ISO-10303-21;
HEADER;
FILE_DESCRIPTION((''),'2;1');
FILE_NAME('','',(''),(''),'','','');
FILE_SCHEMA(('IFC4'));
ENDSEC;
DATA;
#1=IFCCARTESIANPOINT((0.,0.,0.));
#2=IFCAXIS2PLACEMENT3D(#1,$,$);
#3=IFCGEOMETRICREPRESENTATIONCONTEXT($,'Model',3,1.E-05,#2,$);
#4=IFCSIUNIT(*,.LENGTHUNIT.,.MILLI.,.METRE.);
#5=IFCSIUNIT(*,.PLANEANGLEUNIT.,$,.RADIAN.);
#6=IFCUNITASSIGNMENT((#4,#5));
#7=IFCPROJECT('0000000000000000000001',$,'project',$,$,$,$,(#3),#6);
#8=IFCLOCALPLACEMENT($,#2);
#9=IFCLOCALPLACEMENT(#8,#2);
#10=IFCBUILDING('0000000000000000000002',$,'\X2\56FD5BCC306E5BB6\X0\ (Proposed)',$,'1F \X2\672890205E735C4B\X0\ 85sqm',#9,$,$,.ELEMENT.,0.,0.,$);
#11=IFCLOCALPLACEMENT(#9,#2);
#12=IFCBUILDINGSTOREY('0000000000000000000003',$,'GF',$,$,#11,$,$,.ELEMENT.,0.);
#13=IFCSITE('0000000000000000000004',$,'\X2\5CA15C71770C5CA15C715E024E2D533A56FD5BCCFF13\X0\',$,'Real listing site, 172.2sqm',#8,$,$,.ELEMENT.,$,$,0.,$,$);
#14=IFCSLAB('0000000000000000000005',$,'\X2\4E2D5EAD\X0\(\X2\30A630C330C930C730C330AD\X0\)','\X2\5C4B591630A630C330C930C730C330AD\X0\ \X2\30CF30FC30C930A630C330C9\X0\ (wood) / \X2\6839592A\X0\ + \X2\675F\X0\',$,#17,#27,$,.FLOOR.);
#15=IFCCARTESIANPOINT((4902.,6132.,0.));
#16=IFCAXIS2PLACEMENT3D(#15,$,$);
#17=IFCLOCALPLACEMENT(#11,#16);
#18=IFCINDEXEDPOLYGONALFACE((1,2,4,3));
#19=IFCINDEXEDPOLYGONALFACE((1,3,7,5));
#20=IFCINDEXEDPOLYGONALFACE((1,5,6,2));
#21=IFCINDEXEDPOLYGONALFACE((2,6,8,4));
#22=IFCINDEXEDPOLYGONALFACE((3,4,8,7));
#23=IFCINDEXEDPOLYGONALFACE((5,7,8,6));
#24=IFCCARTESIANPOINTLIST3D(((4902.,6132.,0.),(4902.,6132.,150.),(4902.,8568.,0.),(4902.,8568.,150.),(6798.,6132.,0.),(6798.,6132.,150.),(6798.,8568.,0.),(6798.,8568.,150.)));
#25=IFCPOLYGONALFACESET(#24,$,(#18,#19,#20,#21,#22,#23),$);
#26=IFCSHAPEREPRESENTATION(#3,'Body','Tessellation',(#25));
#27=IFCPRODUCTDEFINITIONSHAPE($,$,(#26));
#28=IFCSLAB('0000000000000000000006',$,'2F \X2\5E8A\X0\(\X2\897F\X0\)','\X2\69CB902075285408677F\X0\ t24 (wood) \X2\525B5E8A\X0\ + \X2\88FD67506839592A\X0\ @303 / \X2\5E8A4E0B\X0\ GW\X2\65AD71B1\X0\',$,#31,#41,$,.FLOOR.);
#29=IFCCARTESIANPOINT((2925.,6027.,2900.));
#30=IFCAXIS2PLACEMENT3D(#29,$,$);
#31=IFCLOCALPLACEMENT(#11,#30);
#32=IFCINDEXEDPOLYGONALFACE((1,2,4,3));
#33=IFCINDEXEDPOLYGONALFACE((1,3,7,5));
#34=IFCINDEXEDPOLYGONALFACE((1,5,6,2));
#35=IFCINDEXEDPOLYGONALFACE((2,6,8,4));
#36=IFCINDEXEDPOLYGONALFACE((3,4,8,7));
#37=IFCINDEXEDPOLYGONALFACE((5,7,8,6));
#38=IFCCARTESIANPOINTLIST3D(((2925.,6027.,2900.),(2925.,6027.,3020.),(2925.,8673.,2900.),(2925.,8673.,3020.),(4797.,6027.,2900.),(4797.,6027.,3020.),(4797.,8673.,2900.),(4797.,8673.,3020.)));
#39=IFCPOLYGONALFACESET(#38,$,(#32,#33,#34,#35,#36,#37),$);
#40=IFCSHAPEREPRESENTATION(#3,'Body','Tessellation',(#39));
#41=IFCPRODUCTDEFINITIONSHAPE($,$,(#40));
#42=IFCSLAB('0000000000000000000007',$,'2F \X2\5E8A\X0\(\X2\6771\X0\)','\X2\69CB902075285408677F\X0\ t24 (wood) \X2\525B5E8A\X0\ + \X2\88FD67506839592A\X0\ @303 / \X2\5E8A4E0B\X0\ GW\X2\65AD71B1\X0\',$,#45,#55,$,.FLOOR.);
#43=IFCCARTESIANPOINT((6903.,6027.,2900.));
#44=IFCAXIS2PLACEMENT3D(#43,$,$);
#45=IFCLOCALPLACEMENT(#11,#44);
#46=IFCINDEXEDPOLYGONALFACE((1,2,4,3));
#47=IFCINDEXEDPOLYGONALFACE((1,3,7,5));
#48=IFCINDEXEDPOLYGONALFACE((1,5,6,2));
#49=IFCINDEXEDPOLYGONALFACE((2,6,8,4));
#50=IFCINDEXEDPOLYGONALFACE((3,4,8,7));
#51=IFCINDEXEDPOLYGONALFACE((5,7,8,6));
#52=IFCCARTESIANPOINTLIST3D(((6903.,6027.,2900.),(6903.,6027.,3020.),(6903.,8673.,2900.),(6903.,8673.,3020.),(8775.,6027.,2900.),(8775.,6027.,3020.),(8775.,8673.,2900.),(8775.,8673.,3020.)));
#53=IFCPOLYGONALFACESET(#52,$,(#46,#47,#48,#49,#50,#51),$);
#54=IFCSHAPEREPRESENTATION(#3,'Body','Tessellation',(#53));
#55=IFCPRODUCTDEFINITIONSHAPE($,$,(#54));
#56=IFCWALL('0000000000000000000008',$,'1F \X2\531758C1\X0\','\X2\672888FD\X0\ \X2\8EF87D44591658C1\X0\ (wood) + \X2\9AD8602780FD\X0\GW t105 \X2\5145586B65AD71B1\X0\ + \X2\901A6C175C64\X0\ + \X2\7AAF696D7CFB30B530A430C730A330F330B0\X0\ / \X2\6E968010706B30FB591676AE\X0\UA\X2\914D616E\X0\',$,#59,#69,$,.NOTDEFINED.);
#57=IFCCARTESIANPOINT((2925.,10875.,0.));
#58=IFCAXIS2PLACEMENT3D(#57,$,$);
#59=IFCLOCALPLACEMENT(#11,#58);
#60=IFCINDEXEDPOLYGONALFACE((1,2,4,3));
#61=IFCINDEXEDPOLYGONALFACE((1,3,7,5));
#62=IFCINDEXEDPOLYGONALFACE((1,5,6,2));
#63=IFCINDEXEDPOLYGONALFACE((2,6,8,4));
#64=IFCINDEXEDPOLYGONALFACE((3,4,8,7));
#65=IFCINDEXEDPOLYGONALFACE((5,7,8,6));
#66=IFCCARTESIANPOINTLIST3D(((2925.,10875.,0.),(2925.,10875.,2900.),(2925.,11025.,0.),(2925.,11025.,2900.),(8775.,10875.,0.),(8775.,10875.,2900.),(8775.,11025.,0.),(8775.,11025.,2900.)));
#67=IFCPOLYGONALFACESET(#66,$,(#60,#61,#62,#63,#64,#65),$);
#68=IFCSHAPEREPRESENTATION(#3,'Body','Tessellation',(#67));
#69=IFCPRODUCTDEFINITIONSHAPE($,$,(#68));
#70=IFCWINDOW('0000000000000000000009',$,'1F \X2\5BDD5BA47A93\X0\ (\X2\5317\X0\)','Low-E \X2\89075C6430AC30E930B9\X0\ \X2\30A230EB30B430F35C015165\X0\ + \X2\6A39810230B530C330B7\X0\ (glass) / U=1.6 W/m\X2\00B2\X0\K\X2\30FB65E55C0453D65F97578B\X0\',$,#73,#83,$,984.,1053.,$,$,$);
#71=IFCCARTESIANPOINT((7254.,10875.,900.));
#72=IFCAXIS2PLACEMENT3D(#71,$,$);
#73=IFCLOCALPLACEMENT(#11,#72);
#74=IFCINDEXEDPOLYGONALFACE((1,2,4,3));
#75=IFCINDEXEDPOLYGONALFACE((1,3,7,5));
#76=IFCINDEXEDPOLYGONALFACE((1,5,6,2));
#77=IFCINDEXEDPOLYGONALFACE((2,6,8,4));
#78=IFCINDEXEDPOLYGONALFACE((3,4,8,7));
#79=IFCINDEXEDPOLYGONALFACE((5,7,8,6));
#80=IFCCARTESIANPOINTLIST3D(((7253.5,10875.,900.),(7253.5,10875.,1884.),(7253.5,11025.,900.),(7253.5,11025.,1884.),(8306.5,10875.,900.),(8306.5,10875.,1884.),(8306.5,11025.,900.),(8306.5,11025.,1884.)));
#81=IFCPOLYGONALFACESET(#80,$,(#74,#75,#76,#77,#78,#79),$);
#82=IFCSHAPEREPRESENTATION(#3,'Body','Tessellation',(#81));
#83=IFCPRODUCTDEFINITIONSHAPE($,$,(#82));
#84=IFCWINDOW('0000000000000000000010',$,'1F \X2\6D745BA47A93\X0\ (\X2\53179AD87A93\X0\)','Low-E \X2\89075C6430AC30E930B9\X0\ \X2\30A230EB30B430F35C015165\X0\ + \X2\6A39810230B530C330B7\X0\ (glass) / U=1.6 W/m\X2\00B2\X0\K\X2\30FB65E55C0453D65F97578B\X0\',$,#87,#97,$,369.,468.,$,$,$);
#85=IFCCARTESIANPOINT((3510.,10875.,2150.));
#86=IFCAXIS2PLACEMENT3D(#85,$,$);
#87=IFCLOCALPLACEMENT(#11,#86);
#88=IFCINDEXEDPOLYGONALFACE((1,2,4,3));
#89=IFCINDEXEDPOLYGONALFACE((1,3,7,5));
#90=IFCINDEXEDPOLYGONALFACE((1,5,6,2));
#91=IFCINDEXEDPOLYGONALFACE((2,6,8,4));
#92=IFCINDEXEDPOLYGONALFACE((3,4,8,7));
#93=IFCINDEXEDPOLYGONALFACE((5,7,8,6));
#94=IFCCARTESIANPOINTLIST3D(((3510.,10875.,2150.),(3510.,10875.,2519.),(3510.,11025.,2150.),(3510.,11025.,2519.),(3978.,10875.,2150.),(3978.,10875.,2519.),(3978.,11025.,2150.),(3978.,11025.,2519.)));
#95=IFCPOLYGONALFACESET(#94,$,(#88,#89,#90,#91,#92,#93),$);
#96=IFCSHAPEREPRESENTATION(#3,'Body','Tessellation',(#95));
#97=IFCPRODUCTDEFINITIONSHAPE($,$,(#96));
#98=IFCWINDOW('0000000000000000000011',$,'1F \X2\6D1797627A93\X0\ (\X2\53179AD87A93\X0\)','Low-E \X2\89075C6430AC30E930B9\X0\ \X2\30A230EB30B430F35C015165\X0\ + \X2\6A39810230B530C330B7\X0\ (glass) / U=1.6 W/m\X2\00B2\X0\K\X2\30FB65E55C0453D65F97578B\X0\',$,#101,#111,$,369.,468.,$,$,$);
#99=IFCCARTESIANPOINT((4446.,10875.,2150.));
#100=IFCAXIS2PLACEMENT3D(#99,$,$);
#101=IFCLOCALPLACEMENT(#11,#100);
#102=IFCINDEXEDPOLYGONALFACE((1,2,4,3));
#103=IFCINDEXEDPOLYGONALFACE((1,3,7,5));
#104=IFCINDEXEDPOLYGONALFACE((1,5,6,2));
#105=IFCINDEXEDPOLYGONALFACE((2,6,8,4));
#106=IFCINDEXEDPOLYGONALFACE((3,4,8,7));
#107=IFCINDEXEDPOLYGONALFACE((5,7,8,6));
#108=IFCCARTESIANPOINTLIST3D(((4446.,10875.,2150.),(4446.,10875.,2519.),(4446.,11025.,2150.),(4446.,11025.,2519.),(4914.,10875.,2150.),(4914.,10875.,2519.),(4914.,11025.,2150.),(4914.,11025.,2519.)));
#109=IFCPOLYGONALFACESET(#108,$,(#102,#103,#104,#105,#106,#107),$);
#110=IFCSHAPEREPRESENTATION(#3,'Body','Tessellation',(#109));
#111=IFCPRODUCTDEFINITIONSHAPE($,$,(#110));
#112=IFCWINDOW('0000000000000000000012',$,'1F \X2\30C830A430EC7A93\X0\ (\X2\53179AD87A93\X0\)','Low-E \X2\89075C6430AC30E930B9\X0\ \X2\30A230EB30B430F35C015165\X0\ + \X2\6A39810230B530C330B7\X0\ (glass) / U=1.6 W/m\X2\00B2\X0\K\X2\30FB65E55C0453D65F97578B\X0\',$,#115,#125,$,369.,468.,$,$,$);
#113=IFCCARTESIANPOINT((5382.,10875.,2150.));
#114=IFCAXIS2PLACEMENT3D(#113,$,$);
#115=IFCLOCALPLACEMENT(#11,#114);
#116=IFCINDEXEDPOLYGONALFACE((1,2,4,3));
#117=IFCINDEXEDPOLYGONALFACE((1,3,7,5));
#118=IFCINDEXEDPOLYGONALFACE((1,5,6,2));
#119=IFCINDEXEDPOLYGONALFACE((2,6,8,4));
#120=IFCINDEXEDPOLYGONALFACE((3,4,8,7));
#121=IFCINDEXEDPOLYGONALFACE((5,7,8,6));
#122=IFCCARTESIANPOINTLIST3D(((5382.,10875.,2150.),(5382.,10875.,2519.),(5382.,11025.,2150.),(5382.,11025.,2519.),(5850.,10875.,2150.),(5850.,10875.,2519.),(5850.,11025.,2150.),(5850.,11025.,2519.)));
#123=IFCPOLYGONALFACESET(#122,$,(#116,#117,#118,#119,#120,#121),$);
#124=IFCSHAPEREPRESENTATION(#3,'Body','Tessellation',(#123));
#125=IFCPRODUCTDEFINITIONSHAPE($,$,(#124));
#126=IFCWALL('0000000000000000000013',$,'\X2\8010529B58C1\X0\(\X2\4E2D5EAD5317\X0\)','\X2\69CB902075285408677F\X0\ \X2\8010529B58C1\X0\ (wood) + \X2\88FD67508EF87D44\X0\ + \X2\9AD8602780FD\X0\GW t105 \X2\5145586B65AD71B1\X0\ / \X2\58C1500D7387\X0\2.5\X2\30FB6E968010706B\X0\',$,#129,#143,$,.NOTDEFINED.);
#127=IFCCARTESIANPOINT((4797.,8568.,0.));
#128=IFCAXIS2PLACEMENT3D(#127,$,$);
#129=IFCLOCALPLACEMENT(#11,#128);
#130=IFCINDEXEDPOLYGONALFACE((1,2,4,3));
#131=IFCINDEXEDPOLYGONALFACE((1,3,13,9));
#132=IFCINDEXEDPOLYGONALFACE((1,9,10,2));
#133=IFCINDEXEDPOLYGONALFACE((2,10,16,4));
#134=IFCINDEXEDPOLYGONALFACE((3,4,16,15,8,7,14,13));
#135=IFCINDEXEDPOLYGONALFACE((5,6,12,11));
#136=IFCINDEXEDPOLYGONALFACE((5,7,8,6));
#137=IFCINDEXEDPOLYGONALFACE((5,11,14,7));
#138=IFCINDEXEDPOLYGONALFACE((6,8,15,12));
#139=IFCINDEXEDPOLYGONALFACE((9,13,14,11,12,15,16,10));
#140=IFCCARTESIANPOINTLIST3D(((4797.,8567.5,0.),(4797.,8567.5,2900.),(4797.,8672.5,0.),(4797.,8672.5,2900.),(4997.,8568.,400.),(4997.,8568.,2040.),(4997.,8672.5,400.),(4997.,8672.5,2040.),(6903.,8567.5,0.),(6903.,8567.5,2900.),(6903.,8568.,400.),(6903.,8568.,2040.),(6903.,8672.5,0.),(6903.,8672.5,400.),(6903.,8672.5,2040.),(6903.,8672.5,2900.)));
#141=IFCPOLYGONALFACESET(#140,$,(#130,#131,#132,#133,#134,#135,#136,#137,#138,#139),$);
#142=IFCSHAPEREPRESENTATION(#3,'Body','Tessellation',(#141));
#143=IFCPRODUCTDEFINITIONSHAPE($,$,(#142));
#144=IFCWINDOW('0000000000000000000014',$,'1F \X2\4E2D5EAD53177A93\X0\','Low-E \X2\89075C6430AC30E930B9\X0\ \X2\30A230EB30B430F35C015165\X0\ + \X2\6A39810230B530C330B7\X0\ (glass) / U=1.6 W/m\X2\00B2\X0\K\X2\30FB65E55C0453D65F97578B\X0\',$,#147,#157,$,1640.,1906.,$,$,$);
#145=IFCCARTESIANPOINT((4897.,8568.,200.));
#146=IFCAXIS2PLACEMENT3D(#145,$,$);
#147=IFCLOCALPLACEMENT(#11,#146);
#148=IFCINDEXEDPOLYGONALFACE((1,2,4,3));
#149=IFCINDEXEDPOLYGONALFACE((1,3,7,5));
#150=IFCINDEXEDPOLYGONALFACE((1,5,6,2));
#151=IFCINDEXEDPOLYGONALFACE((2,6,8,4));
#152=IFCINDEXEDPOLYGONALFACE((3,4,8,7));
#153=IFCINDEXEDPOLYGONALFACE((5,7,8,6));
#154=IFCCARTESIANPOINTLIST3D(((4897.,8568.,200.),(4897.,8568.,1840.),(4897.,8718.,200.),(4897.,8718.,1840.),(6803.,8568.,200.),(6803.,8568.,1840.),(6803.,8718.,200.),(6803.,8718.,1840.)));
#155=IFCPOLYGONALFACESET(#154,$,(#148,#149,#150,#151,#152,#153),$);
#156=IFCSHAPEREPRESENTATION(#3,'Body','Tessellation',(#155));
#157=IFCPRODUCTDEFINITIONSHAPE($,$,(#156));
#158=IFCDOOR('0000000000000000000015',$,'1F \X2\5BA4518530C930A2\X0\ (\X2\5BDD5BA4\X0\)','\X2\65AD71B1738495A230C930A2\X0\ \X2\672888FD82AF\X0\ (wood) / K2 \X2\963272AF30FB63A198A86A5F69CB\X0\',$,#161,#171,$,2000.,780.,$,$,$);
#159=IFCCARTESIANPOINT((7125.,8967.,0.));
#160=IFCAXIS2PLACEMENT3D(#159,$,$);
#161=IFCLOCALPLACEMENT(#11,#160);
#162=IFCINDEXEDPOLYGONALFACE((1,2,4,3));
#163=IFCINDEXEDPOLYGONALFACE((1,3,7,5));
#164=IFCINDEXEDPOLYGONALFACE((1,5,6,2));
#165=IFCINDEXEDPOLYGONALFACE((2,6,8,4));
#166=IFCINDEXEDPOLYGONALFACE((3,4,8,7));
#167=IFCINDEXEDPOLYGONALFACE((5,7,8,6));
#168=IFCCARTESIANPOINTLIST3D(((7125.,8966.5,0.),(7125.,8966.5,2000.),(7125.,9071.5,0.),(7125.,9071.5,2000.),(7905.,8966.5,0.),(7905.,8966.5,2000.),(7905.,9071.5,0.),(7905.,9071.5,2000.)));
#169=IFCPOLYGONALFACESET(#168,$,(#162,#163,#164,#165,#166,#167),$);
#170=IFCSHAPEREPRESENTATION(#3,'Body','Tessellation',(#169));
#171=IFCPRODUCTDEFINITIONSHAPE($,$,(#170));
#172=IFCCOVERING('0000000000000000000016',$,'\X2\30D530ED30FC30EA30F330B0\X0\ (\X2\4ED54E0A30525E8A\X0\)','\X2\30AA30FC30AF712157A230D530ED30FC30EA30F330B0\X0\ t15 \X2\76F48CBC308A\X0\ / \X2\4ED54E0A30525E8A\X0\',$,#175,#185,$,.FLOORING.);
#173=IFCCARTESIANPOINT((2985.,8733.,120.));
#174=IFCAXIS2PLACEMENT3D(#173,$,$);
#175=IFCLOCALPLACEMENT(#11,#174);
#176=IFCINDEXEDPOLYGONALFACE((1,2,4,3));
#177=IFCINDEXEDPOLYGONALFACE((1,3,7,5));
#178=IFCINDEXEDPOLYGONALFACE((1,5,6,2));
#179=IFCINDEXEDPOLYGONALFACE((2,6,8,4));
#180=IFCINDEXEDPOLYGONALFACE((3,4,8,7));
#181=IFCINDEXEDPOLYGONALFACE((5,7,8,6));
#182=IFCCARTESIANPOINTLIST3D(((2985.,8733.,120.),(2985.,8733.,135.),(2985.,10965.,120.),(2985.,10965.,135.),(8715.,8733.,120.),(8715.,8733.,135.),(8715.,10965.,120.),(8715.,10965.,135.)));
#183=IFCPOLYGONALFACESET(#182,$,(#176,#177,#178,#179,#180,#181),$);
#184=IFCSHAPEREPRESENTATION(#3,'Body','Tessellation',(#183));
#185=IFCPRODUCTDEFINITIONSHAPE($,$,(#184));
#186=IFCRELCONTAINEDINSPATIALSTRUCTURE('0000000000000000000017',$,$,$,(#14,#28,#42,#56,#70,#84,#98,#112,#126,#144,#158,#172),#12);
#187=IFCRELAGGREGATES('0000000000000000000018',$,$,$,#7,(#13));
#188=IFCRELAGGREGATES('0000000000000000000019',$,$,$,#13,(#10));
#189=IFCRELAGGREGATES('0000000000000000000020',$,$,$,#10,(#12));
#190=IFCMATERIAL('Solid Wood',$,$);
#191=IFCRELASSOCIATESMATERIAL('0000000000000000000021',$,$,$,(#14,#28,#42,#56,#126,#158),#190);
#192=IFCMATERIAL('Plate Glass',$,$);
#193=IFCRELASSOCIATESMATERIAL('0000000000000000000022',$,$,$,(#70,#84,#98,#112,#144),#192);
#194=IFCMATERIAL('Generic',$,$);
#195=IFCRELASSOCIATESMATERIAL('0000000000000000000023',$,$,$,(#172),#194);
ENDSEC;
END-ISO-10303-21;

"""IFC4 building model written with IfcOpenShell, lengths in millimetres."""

from ifc_helpers import new_model, si_unit, frame, frame_2d, origin, place, context, project, spatial, rectangle, extrude, material, element, fill, save


model = new_model("IFC4")

# Units and contexts
model_context = context("Model", 3, precision=1e-05, world=origin())
ifc_project = project(units=[si_unit("LENGTHUNIT", "METRE", prefix="MILLI"), si_unit("PLANEANGLEUNIT", "RADIAN")], contexts=[model_context])

# Site, building, storey
site_placement = place(None, origin())
site = spatial("IfcSite", under=ifc_project, at=site_placement, Name="岡山県岡山市中区国富３", ObjectType="Real listing site, 172.2sqm", CompositionType="ELEMENT", RefElevation=0.0)
building_placement = place(site_placement, origin())
building = spatial("IfcBuilding", under=site, at=building_placement, Name="国富の家 (Proposed)", ObjectType="1F 木造平屋 85sqm", CompositionType="ELEMENT", ElevationOfRefHeight=0.0, ElevationOfTerrain=0.0)
storey_placement = place(building_placement, origin())
storey = spatial("IfcBuildingStorey", under=building, at=storey_placement, Name="GF", CompositionType="ELEMENT", Elevation=0.0)

# Slabs
ifc_material_1 = material(Name="Solid Wood")
slab_1_placement = place(storey_placement, frame((4902.0, 6132.0, 0.0)))
element("IfcSlab", 1, at=slab_1_placement, inside=storey, material=ifc_material_1, Name="中庭(ウッドデッキ)", Description="屋外ウッドデッキ ハードウッド (wood) / 根太 + 束", PredefinedType="FLOOR", context=model_context, shape_type="SweptSolid", body=[
    extrude(rectangle(XDim=1896.0, YDim=2436.0, at=frame_2d((948.0, 1218.0))), frame((4902.0, 6132.0, 0.0)), (0.0, 0.0, 1.0), 150.0),
])
slab_2_placement = place(storey_placement, frame((2925.0, 6027.0, 2900.0)))
element("IfcSlab", 2, at=slab_2_placement, inside=storey, material=ifc_material_1, Name="2F 床(西)", Description="構造用合板 t24 (wood) 剛床 + 製材根太 @303 / 床下 GW断熱", PredefinedType="FLOOR", context=model_context, shape_type="SweptSolid", body=[
    extrude(rectangle(XDim=1872.0, YDim=2646.0, at=frame_2d((936.0, 1323.0))), frame((2925.0, 6027.0, 2900.0)), (0.0, 0.0, 1.0), 120.0),
])
slab_3_placement = place(storey_placement, frame((6903.0, 6027.0, 2900.0)))
element("IfcSlab", 3, at=slab_3_placement, inside=storey, material=ifc_material_1, Name="2F 床(東)", Description="構造用合板 t24 (wood) 剛床 + 製材根太 @303 / 床下 GW断熱", PredefinedType="FLOOR", context=model_context, shape_type="SweptSolid", body=[
    extrude(rectangle(XDim=1872.0, YDim=2646.0, at=frame_2d((936.0, 1323.0))), frame((6903.0, 6027.0, 2900.0)), (0.0, 0.0, 1.0), 120.0),
])

# Wall, openings, windows
wall_1_placement = place(storey_placement, frame((2925.0, 10875.0, 0.0)))
wall_1 = element("IfcWall", 4, at=wall_1_placement, inside=storey, material=ifc_material_1, Name="1F 北壁", Description="木製 軸組外壁 (wood) + 高性能GW t105 充填断熱 + 通気層 + 窯業系サイディング / 準耐火・外皮UA配慮", PredefinedType="NOTDEFINED", context=model_context, shape_type="SweptSolid", body=[
    extrude(rectangle(XDim=5850.0, YDim=150.0, at=frame_2d((2925.0, 75.0))), frame((2925.0, 10875.0, 0.0)), (0.0, 0.0, 1.0), 2900.0),
])
opening_1_placement = place(storey_placement, frame((7254.0, 10875.0, 900.0)))
opening_1 = element("IfcOpeningElement", 5, at=opening_1_placement, cuts=wall_1, PredefinedType="NOTDEFINED", context=model_context, shape_type="SweptSolid", body=[
    extrude(rectangle(XDim=1053.0, YDim=150.0, at=frame_2d((526.0, 75.0))), frame((7254.0, 10875.0, 900.0)), (0.0, 0.0, 1.0), 984.0),
])
opening_2_placement = place(storey_placement, frame((3510.0, 10875.0, 2150.0)))
opening_2 = element("IfcOpeningElement", 6, at=opening_2_placement, cuts=wall_1, PredefinedType="NOTDEFINED", context=model_context, shape_type="SweptSolid", body=[
    extrude(rectangle(XDim=468.0, YDim=150.0, at=frame_2d((234.0, 75.0))), frame((3510.0, 10875.0, 2150.0)), (0.0, 0.0, 1.0), 369.0),
])
opening_3_placement = place(storey_placement, frame((4446.0, 10875.0, 2150.0)))
opening_3 = element("IfcOpeningElement", 7, at=opening_3_placement, cuts=wall_1, PredefinedType="NOTDEFINED", context=model_context, shape_type="SweptSolid", body=[
    extrude(rectangle(XDim=468.0, YDim=150.0, at=frame_2d((234.0, 75.0))), frame((4446.0, 10875.0, 2150.0)), (0.0, 0.0, 1.0), 369.0),
])
opening_4_placement = place(storey_placement, frame((5382.0, 10875.0, 2150.0)))
opening_4 = element("IfcOpeningElement", 8, at=opening_4_placement, cuts=wall_1, PredefinedType="NOTDEFINED", context=model_context, shape_type="SweptSolid", body=[
    extrude(rectangle(XDim=468.0, YDim=150.0, at=frame_2d((234.0, 75.0))), frame((5382.0, 10875.0, 2150.0)), (0.0, 0.0, 1.0), 369.0),
])
ifc_material_2 = material(Name="Plate Glass")
window_1_placement = place(storey_placement, frame((7254.0, 10875.0, 900.0)))
window_1 = element("IfcWindow", 9, at=window_1_placement, inside=storey, material=ifc_material_2, Name="1F 寝室窓 (北)", Description="Low-E 複層ガラス アルゴン封入 + 樹脂サッシ (glass) / U=1.6 W/m²K・日射取得型", OverallHeight=984.0, OverallWidth=1053.0, context=model_context, shape_type="SweptSolid", body=[
    extrude(rectangle(XDim=1053.0, YDim=150.0, at=frame_2d((526.0, 75.0))), frame((7254.0, 10875.0, 900.0)), (0.0, 0.0, 1.0), 984.0),
])
fill(opening_1, window_1)
window_2_placement = place(storey_placement, frame((3510.0, 10875.0, 2150.0)))
window_2 = element("IfcWindow", 10, at=window_2_placement, inside=storey, material=ifc_material_2, Name="1F 浴室窓 (北高窓)", Description="Low-E 複層ガラス アルゴン封入 + 樹脂サッシ (glass) / U=1.6 W/m²K・日射取得型", OverallHeight=369.0, OverallWidth=468.0, context=model_context, shape_type="SweptSolid", body=[
    extrude(rectangle(XDim=468.0, YDim=150.0, at=frame_2d((234.0, 75.0))), frame((3510.0, 10875.0, 2150.0)), (0.0, 0.0, 1.0), 369.0),
])
fill(opening_2, window_2)
window_3_placement = place(storey_placement, frame((4446.0, 10875.0, 2150.0)))
window_3 = element("IfcWindow", 11, at=window_3_placement, inside=storey, material=ifc_material_2, Name="1F 洗面窓 (北高窓)", Description="Low-E 複層ガラス アルゴン封入 + 樹脂サッシ (glass) / U=1.6 W/m²K・日射取得型", OverallHeight=369.0, OverallWidth=468.0, context=model_context, shape_type="SweptSolid", body=[
    extrude(rectangle(XDim=468.0, YDim=150.0, at=frame_2d((234.0, 75.0))), frame((4446.0, 10875.0, 2150.0)), (0.0, 0.0, 1.0), 369.0),
])
fill(opening_3, window_3)
window_4_placement = place(storey_placement, frame((5382.0, 10875.0, 2150.0)))
window_4 = element("IfcWindow", 12, at=window_4_placement, inside=storey, material=ifc_material_2, Name="1F トイレ窓 (北高窓)", Description="Low-E 複層ガラス アルゴン封入 + 樹脂サッシ (glass) / U=1.6 W/m²K・日射取得型", OverallHeight=369.0, OverallWidth=468.0, context=model_context, shape_type="SweptSolid", body=[
    extrude(rectangle(XDim=468.0, YDim=150.0, at=frame_2d((234.0, 75.0))), frame((5382.0, 10875.0, 2150.0)), (0.0, 0.0, 1.0), 369.0),
])
fill(opening_4, window_4)

# Wall, opening, window
wall_2_placement = place(storey_placement, frame((4797.0, 8568.0, 0.0)))
wall_2 = element("IfcWall", 13, at=wall_2_placement, inside=storey, material=ifc_material_1, Name="耐力壁(中庭北)", Description="構造用合板 耐力壁 (wood) + 製材軸組 + 高性能GW t105 充填断熱 / 壁倍率2.5・準耐火", PredefinedType="NOTDEFINED", context=model_context, shape_type="SweptSolid", body=[
    extrude(rectangle(XDim=2106.0, YDim=105.0, at=frame_2d((1053.0, 52.0))), frame((4797.0, 8568.0, 0.0)), (0.0, 0.0, 1.0), 2900.0),
])
opening_5_placement = place(storey_placement, frame((4897.0, 8568.0, 200.0)))
opening_5 = element("IfcOpeningElement", 14, at=opening_5_placement, cuts=wall_2, PredefinedType="NOTDEFINED", context=model_context, shape_type="SweptSolid", body=[
    extrude(rectangle(XDim=1906.0, YDim=150.0, at=frame_2d((953.0, 75.0))), frame((4897.0, 8568.0, 200.0)), (0.0, 0.0, 1.0), 1640.0),
])
window_5_placement = place(storey_placement, frame((4897.0, 8568.0, 200.0)))
window_5 = element("IfcWindow", 15, at=window_5_placement, inside=storey, material=ifc_material_2, Name="1F 中庭北窓", Description="Low-E 複層ガラス アルゴン封入 + 樹脂サッシ (glass) / U=1.6 W/m²K・日射取得型", OverallHeight=1640.0, OverallWidth=1906.0, context=model_context, shape_type="SweptSolid", body=[
    extrude(rectangle(XDim=1906.0, YDim=150.0, at=frame_2d((953.0, 75.0))), frame((4897.0, 8568.0, 200.0)), (0.0, 0.0, 1.0), 1640.0),
])
fill(opening_5, window_5)

# Door
door_1_placement = place(storey_placement, frame((7125.0, 8967.0, 0.0)))
element("IfcDoor", 16, at=door_1_placement, inside=storey, material=ifc_material_1, Name="1F 室内ドア (寝室)", Description="断熱玄関ドア 木製芯 (wood) / K2 防犯・採風機構", OverallHeight=2000.0, OverallWidth=780.0, context=model_context, shape_type="SweptSolid", body=[
    extrude(rectangle(XDim=780.0, YDim=105.0, at=frame_2d((390.0, 52.0))), frame((7125.0, 8967.0, 0.0)), (0.0, 0.0, 1.0), 2000.0),
])

# Covering
ifc_material_3 = material(Name="Generic")
covering_1_placement = place(storey_placement, frame((2985.0, 8733.0, 120.0)))
element("IfcCovering", 17, at=covering_1_placement, inside=storey, material=ifc_material_3, Name="フローリング (仕上げ床)", Description="オーク無垢フローリング t15 直貼り / 仕上げ床", PredefinedType="FLOORING", context=model_context, shape_type="SweptSolid", body=[
    extrude(rectangle(XDim=5730.0, YDim=2232.0, at=frame_2d((2865.0, 1116.0))), frame((2985.0, 8733.0, 120.0)), (0.0, 0.0, 1.0), 15.0),
])

save(model, "model.ifc")
